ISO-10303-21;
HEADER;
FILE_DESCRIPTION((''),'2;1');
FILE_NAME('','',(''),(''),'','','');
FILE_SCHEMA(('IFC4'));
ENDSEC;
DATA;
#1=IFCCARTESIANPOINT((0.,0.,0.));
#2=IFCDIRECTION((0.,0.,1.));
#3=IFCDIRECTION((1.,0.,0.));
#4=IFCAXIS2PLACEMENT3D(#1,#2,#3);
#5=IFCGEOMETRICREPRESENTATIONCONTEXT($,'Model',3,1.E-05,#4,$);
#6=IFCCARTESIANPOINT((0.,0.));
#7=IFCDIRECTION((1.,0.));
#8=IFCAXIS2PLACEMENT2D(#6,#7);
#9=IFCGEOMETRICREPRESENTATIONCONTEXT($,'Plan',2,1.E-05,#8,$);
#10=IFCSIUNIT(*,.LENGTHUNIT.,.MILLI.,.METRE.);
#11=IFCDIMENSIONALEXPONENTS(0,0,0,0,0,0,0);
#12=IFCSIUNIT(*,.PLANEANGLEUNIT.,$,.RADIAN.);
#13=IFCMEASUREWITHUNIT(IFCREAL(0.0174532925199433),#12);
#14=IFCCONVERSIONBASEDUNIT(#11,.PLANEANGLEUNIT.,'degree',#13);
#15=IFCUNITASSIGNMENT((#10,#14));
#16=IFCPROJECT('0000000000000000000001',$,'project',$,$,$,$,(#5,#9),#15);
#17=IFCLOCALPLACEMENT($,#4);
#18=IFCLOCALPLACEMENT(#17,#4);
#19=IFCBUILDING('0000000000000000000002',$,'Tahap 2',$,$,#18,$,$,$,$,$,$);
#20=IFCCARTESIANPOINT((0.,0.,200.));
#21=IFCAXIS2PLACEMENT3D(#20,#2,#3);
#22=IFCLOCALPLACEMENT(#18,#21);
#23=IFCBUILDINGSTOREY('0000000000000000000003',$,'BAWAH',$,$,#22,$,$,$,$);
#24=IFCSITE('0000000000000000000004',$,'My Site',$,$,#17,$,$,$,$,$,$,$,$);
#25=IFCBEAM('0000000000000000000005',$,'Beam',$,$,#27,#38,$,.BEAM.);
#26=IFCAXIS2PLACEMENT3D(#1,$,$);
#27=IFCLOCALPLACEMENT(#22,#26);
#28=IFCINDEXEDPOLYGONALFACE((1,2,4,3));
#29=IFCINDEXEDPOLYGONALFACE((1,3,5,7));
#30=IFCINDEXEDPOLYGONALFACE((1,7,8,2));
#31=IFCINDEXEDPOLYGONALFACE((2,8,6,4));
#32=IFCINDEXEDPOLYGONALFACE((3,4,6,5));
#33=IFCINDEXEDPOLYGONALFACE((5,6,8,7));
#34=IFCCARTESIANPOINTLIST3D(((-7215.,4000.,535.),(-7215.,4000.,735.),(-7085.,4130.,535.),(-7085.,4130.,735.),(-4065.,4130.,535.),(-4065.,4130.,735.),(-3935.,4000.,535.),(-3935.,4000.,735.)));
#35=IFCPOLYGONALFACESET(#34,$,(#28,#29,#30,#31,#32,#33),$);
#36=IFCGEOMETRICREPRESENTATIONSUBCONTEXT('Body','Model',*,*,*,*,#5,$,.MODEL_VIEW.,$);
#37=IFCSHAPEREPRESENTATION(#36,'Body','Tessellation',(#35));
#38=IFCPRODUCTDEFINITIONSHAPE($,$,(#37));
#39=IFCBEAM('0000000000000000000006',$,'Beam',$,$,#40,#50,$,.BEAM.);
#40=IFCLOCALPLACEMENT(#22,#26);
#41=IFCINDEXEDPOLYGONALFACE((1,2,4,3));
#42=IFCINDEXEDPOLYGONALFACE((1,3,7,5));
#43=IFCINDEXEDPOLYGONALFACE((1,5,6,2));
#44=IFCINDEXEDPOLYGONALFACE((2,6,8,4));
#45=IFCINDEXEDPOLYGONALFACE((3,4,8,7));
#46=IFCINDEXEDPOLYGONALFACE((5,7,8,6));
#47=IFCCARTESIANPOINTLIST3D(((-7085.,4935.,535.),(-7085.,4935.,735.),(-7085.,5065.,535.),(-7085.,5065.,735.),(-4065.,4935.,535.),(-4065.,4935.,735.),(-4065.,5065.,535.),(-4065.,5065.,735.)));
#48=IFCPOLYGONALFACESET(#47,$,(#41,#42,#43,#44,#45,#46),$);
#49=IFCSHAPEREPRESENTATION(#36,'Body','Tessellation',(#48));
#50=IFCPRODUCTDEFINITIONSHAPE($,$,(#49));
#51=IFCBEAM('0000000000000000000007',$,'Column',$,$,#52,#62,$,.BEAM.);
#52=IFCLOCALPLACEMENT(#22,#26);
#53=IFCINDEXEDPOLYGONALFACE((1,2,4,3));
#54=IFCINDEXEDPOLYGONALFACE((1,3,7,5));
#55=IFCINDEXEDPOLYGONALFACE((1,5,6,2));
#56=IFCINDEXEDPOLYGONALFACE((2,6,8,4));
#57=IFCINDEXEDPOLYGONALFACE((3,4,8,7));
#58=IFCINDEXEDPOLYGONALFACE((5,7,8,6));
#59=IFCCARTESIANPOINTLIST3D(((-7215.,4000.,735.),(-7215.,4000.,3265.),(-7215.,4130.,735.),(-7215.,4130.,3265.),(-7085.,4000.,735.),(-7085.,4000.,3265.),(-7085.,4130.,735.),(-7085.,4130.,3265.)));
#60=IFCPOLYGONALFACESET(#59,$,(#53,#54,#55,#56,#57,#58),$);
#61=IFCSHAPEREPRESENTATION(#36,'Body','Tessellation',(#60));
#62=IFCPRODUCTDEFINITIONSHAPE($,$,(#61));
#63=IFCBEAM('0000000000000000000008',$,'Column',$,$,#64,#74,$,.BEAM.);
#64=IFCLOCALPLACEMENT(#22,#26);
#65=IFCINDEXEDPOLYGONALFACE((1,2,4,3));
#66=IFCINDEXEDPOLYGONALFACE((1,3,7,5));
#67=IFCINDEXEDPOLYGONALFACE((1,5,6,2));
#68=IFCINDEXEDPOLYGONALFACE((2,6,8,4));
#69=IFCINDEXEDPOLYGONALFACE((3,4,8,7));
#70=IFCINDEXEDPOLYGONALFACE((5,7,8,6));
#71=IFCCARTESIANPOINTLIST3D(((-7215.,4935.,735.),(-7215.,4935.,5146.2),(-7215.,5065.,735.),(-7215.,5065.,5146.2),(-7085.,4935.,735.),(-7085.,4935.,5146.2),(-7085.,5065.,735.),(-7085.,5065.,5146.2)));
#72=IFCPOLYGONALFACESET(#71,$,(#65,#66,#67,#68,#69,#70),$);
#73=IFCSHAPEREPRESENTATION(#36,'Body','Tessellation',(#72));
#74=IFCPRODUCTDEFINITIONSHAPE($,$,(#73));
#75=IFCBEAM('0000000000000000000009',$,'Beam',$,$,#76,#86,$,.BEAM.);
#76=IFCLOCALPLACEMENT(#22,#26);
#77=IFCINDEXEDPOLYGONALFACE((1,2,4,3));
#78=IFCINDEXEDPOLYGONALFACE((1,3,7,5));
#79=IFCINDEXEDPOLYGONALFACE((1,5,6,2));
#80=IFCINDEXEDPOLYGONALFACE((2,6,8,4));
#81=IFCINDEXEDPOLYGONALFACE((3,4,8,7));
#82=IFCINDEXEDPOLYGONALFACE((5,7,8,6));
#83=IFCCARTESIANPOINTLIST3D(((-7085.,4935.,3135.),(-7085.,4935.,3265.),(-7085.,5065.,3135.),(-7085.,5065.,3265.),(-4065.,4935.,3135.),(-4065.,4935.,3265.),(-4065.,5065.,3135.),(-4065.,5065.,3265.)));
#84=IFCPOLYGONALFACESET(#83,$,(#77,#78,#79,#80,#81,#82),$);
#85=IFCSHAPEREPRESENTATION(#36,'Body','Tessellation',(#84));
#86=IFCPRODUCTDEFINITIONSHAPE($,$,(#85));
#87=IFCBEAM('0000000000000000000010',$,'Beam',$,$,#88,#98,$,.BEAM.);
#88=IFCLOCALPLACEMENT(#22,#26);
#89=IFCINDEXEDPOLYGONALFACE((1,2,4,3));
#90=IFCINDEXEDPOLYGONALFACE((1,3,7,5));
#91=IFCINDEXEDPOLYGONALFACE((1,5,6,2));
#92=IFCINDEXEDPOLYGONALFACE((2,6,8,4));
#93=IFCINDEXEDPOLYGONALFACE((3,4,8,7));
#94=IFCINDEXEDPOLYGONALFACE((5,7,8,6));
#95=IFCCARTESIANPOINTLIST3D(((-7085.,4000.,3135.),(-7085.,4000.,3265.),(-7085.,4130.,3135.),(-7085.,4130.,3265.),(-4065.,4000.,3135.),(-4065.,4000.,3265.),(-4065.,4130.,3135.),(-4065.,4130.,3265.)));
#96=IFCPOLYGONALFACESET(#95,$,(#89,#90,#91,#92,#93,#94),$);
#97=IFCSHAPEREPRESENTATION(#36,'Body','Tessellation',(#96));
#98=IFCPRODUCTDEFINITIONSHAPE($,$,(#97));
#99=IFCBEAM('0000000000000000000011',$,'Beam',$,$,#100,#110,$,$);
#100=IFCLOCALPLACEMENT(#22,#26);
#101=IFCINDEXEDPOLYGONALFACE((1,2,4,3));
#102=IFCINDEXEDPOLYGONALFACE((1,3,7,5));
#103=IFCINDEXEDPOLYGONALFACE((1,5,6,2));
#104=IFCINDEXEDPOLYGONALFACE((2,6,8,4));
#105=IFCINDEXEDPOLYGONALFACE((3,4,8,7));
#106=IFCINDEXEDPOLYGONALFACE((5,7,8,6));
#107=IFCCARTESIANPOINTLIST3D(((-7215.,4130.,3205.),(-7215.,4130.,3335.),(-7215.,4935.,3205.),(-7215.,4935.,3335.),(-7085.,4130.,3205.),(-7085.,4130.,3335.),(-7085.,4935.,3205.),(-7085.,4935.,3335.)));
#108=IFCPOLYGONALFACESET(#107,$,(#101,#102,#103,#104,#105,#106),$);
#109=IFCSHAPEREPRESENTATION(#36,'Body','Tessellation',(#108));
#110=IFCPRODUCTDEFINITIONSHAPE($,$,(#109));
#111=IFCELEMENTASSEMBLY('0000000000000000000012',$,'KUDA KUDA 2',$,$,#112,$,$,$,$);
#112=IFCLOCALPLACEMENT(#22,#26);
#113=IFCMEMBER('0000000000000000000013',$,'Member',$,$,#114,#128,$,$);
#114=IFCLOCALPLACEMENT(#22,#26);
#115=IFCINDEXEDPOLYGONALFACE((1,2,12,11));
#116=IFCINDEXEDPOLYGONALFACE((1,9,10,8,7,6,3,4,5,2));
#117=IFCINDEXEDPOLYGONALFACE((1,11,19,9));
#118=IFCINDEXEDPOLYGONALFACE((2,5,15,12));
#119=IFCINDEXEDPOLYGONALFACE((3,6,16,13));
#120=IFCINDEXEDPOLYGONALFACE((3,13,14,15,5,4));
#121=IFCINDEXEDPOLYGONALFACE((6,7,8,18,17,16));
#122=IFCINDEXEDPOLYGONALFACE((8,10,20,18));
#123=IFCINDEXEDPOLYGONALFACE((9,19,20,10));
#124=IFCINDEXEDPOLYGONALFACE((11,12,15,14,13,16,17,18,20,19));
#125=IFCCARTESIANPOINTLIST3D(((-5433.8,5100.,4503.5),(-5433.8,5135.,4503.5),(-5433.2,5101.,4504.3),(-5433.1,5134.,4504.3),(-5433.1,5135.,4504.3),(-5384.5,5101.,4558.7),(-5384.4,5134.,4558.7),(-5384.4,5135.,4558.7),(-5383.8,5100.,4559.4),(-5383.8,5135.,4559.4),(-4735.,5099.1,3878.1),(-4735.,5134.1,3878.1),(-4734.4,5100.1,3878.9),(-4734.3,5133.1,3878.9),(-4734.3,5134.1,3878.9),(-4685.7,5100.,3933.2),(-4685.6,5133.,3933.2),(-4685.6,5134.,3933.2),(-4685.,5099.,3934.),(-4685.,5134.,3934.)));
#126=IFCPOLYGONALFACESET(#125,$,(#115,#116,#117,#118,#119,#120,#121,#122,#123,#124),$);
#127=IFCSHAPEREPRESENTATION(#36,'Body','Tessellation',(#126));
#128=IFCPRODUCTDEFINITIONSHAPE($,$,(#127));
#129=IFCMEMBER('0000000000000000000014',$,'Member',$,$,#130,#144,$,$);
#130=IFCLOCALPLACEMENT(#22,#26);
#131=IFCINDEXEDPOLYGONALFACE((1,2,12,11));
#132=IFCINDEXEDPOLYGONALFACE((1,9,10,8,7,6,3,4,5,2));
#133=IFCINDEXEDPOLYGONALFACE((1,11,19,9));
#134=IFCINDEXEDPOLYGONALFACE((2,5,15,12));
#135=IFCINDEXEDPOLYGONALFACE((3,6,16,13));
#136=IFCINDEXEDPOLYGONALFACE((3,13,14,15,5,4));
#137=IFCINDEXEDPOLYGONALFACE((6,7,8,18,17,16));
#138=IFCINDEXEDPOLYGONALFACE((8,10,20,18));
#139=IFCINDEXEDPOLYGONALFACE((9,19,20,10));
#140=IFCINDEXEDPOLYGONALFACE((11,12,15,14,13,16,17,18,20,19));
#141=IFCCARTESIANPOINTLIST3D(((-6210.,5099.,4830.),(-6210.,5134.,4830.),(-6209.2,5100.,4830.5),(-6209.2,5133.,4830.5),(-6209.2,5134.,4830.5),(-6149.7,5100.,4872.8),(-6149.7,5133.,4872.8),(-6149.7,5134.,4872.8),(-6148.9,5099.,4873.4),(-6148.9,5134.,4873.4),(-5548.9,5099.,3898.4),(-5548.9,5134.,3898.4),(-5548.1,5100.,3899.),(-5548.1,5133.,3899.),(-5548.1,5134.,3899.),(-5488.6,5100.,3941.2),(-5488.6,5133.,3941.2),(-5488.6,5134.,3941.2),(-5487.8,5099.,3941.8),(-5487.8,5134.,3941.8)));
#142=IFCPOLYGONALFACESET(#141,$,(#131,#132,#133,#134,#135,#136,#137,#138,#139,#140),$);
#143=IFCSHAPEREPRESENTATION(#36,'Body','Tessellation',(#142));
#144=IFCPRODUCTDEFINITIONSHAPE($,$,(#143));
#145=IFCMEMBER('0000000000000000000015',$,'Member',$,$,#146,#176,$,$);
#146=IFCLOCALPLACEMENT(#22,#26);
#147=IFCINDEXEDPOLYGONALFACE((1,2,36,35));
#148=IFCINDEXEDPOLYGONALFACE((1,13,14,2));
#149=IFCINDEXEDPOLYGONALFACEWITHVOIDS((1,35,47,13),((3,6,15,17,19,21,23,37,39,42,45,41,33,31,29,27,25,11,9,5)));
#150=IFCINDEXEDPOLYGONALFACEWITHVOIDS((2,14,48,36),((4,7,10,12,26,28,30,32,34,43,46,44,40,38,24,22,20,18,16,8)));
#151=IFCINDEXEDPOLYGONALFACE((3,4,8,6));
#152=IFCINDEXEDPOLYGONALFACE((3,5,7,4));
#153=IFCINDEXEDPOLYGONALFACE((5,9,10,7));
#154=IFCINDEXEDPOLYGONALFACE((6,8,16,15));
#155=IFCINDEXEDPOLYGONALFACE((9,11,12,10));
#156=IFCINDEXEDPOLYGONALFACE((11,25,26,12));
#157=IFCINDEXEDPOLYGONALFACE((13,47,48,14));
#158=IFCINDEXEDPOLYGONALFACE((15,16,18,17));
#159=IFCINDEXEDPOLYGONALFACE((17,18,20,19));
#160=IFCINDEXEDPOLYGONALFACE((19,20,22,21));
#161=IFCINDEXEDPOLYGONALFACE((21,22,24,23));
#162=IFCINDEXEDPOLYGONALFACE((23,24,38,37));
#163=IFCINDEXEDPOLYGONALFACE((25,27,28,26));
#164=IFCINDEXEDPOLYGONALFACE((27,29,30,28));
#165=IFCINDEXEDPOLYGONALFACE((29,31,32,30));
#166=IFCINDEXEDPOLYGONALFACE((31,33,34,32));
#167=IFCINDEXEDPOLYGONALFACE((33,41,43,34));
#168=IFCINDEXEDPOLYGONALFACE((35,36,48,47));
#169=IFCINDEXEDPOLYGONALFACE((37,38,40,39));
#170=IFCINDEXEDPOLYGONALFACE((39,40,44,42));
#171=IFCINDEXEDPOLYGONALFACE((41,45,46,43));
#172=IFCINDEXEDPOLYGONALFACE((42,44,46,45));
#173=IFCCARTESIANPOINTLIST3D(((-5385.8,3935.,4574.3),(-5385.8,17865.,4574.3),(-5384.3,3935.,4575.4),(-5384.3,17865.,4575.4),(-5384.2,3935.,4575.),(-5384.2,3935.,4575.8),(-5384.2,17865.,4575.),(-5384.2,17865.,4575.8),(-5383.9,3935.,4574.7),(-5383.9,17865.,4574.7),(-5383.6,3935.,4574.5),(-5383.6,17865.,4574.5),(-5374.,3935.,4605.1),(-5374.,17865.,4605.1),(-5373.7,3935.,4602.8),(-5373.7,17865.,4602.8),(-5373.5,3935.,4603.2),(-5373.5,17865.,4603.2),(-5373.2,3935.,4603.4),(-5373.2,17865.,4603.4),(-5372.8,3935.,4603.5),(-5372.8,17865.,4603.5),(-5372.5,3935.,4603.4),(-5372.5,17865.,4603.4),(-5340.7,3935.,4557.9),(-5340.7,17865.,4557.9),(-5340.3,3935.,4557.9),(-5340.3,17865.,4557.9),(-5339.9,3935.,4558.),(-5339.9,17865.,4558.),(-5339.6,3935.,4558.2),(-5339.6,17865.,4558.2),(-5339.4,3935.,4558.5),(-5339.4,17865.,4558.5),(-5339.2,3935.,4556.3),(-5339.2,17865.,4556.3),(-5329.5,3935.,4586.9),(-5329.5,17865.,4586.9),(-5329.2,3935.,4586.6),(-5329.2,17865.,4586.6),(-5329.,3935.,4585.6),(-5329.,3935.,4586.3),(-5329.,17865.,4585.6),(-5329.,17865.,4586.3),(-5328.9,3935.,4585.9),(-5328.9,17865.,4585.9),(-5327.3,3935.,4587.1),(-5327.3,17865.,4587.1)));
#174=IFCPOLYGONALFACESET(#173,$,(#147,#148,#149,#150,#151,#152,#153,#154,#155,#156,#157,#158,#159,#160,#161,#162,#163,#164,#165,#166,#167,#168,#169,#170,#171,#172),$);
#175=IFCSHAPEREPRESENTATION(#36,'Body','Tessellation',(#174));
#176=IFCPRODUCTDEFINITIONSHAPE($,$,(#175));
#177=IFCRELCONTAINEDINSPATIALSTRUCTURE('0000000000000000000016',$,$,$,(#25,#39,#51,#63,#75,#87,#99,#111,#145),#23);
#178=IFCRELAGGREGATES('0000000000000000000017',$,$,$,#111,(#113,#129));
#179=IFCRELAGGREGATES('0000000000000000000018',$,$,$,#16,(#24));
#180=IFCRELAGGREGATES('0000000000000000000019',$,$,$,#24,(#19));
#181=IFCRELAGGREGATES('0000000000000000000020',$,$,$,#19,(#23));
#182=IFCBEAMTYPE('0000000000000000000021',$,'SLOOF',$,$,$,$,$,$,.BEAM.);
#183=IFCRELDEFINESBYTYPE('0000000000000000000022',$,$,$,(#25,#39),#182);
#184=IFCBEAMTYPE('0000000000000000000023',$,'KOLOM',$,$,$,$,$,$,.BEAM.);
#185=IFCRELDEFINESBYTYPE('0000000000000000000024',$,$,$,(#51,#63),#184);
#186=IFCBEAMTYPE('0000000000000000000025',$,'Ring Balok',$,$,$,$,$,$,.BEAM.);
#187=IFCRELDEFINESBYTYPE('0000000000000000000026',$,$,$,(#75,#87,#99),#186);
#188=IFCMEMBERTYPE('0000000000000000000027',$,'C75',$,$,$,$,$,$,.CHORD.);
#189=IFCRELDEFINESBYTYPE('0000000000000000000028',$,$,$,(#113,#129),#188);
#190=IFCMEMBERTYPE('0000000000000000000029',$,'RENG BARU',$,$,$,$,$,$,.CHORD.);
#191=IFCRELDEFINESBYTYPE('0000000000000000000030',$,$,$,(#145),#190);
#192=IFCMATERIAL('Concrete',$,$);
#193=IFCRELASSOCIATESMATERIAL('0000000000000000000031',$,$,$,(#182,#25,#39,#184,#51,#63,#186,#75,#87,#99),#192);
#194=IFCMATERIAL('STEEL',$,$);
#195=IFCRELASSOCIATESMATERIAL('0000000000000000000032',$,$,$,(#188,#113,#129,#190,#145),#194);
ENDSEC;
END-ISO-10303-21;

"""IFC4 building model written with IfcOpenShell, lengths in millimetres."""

from ifc_helpers import new_model, entity, si_unit, converted_unit, frame, origin_with_axes, origin_2d_with_axis, place, context, subcontext, project, spatial, indexed_curve, rectangle, hollow_rectangle, c_section, outline, extrude, clip, halfspace, material, material_profile, profile_set, profile_usage, type_object, element, aggregate, save


model = new_model("IFC4")

# Units and contexts
model_context = context("Model", 3, precision=1e-05, world=origin_with_axes())
plan_context = context("Plan", 2, precision=1e-05, world=origin_2d_with_axis())
body_context = subcontext(model_context, "Body", "Model", "MODEL_VIEW")
ifc_project = project(units=[si_unit("LENGTHUNIT", "METRE", prefix="MILLI"), converted_unit("PLANEANGLEUNIT", "degree", entity("IfcReal", 0.0174532925199433), si_unit("PLANEANGLEUNIT", "RADIAN"), dimensions=[0, 0, 0, 0, 0, 0, 0])], contexts=[model_context, plan_context])

# Site, building, storey
site_placement = place(None, origin_with_axes())
site = spatial("IfcSite", under=ifc_project, at=site_placement, Name="My Site")
building_placement = place(site_placement, origin_with_axes())
building = spatial("IfcBuilding", under=site, at=building_placement, Name="Tahap 2")
storey_placement = place(building_placement, frame((0.0, 0.0, 200.0), z_axis=(0.0, 0.0, 1.0), x_axis=(1.0, 0.0, 0.0)))
storey = spatial("IfcBuildingStorey", under=building, at=storey_placement, Name="BAWAH")

# Beams
ifc_material_1 = material(Name="Concrete")
ifc_material_profile_1 = material_profile(ifc_material_1, outline(indexed_curve([(-65.0, 100.0), (65.0, 100.0), (65.0, -100.0), (-65.0, -100.0), (-65.0, 100.0)])))
ifc_profile_set_1 = profile_set([ifc_material_profile_1])
ifc_profile_usage_1 = profile_usage(ifc_profile_set_1, cardinal=2)
beam_type_1 = type_object("IfcBeamType", Name="SLOOF", PredefinedType="BEAM", material=ifc_profile_set_1)
beam_1_placement = place(storey_placement, frame((-7215.0, 4065.0, 535.0), z_axis=(1.0, 0.0, 0.0), x_axis=(0.0, 1.0, 0.0)))
element("IfcBeam", 1, at=beam_1_placement, inside=storey, type_object=beam_type_1, material=ifc_profile_usage_1, Name="Beam", PredefinedType="BEAM", context=body_context, shape_type="Clipping", body=[
    clip(clip(extrude(outline(indexed_curve([(-65.0, 100.0), (65.0, 100.0), (65.0, -100.0), (-65.0, -100.0), (-65.0, 100.0)])), frame((0.0, 100.0, 0.0), z_axis=(0.0, 0.0, 1.0), x_axis=(1.0, 0.0, 0.0)), (0.0, 0.0, 1.0), 3280.0), halfspace(frame((-65.0, -735.0, 3280.0), z_axis=(0.707107, 0.0, 0.707107), x_axis=(0.0, -1.0, 0.0)), False)), halfspace(frame((-65.0, -735.0, 0.0), z_axis=(0.707107, 0.0, -0.707107), x_axis=(0.0, -1.0, 0.0)), False)),
])
ifc_profile_usage_2 = profile_usage(ifc_profile_set_1, cardinal=2)
beam_2_placement = place(storey_placement, frame((-7085.0, 5000.0, 535.0), z_axis=(1.0, 0.0, 0.0), x_axis=(0.0, 1.0, 0.0)))
element("IfcBeam", 2, at=beam_2_placement, inside=storey, type_object=beam_type_1, material=ifc_profile_usage_2, Name="Beam", PredefinedType="BEAM", context=body_context, shape_type="SweptSolid", body=[
    extrude(outline(indexed_curve([(-65.0, 100.0), (65.0, 100.0), (65.0, -100.0), (-65.0, -100.0), (-65.0, 100.0)])), frame((0.0, 100.0, 0.0), z_axis=(0.0, 0.0, 1.0), x_axis=(1.0, 0.0, 0.0)), (0.0, 0.0, 1.0), 3020.0),
])
ifc_material_profile_2 = material_profile(ifc_material_1, rectangle(XDim=130.0, YDim=130.0, kind="CURVE"))
ifc_profile_set_2 = profile_set([ifc_material_profile_2])
ifc_profile_usage_3 = profile_usage(ifc_profile_set_2, cardinal=5)
beam_type_2 = type_object("IfcBeamType", Name="KOLOM", PredefinedType="BEAM", material=ifc_profile_set_2)
beam_3_placement = place(storey_placement, frame((-7150.0, 4065.0, 735.0), z_axis=(0.0, 0.0, 1.0), x_axis=(1.0, 0.0, 0.0)))
element("IfcBeam", 3, at=beam_3_placement, inside=storey, type_object=beam_type_2, material=ifc_profile_usage_3, Name="Column", PredefinedType="BEAM", context=body_context, shape_type="SweptSolid", body=[
    extrude(rectangle(XDim=130.0, YDim=130.0, kind="CURVE"), origin_with_axes(), (0.0, 0.0, 1.0), 2530.0),
])
ifc_profile_usage_4 = profile_usage(ifc_profile_set_2, cardinal=5)
beam_4_placement = place(storey_placement, frame((-7150.0, 5000.0, 735.0), z_axis=(0.0, 0.0, 1.0), x_axis=(1.0, 0.0, 0.0)))
element("IfcBeam", 4, at=beam_4_placement, inside=storey, type_object=beam_type_2, material=ifc_profile_usage_4, Name="Column", PredefinedType="BEAM", context=body_context, shape_type="SweptSolid", body=[
    extrude(rectangle(XDim=130.0, YDim=130.0, kind="CURVE"), origin_with_axes(), (0.0, 0.0, 1.0), 4411.2),
])
ifc_material_profile_3 = material_profile(ifc_material_1, rectangle(XDim=130.0, YDim=130.0))
ifc_profile_set_3 = profile_set([ifc_material_profile_3])
ifc_profile_usage_5 = profile_usage(ifc_profile_set_3)
beam_type_3 = type_object("IfcBeamType", Name="Ring Balok", PredefinedType="BEAM", material=ifc_profile_set_3)
beam_5_placement = place(storey_placement, frame((-7085.0, 5000.0, 3200.0), z_axis=(1.0, 0.0, 0.0), x_axis=(0.0, 1.0, 0.0)))
element("IfcBeam", 5, at=beam_5_placement, inside=storey, type_object=beam_type_3, material=ifc_profile_usage_5, Name="Beam", PredefinedType="BEAM", context=body_context, shape_type="SweptSolid", body=[
    extrude(rectangle(XDim=130.0, YDim=130.0), origin_with_axes(), (0.0, 0.0, 1.0), 3020.0),
])
ifc_profile_usage_6 = profile_usage(ifc_profile_set_3)
beam_6_placement = place(storey_placement, frame((-7085.0, 4065.0, 3200.0), z_axis=(1.0, 0.0, 0.0), x_axis=(0.0, 1.0, 0.0)))
element("IfcBeam", 6, at=beam_6_placement, inside=storey, type_object=beam_type_3, material=ifc_profile_usage_6, Name="Beam", PredefinedType="BEAM", context=body_context, shape_type="SweptSolid", body=[
    extrude(rectangle(XDim=130.0, YDim=130.0), origin_with_axes(), (0.0, 0.0, 1.0), 3020.0),
])
ifc_profile_usage_7 = profile_usage(ifc_profile_set_3, cardinal=9)
beam_7_placement = place(storey_placement, frame((-7085.0, 4130.0, 3335.0), z_axis=(0.0, 1.0, 0.0), x_axis=(-1.0, 0.0, 0.0)))
element("IfcBeam", 7, at=beam_7_placement, inside=storey, type_object=beam_type_3, material=ifc_profile_usage_7, Name="Beam", context=body_context, shape_type="SweptSolid", body=[
    extrude(rectangle(XDim=130.0, YDim=130.0), frame((65.0, -65.0, 0.0), z_axis=(0.0, 0.0, 1.0), x_axis=(1.0, 0.0, 0.0)), (0.0, 0.0, 1.0), 805.0),
])

# Element assembly, members
assembly_placement = place(storey_placement, frame((-3938.5, 5099.0, 3935.3), z_axis=(0.0, 0.0, 1.0), x_axis=(1.0, 0.0, 0.0)))
assembly = element("IfcElementAssembly", 8, at=assembly_placement, inside=storey, Name="KUDA KUDA 2")
ifc_material_2 = material(Name="STEEL")
ifc_material_profile_4 = material_profile(ifc_material_2, c_section(Depth=75.0, Width=35.0, WallThickness=1.0, Girth=1.0, kind="CURVE"))
ifc_profile_set_4 = profile_set([ifc_material_profile_4])
member_type_1 = type_object("IfcMemberType", Name="C75", PredefinedType="CHORD", material=ifc_profile_set_4)
ifc_profile_usage_8 = profile_usage(ifc_profile_set_4, cardinal=7)
member_1_placement = place(assembly_placement, frame((-1445.3, 36.0, 624.1), z_axis=(0.745142, -0.001027, -0.666905), x_axis=(0.001378, 0.999999, 0.0)))
member_1 = element("IfcMember", 9, at=member_1_placement, type_object=member_type_1, material=ifc_profile_usage_8, Name="Member", context=body_context, shape_type="SweptSolid", body=[
    extrude(c_section(Depth=75.0, Width=35.0, WallThickness=1.0, Girth=1.0, kind="CURVE"), frame((-17.5, -37.5, 0.0), z_axis=(0.0, 0.0, 1.0), x_axis=(1.0, 0.0, 0.0)), (0.0, 0.0, 1.0), 937.8),
])
ifc_profile_usage_9 = profile_usage(ifc_profile_set_4, cardinal=3)
member_2_placement = place(assembly_placement, frame((-2271.5, 0.0, 894.6), z_axis=(0.578723, -0.000001, -0.815524), x_axis=(0.000001, 1.0, 0.0)))
member_2 = element("IfcMember", 10, at=member_2_placement, type_object=member_type_1, material=ifc_profile_usage_9, Name="Member", context=body_context, shape_type="SweptSolid", body=[
    extrude(c_section(Depth=75.0, Width=35.0, WallThickness=1.0, Girth=1.0, kind="CURVE"), frame((17.5, 37.5, 0.0), z_axis=(0.0, 0.0, 1.0), x_axis=(1.0, 0.0, 0.0)), (0.0, 0.0, 1.0), 1142.3),
])
aggregate(assembly, [member_1, member_2])

# Member
ifc_material_profile_5 = material_profile(ifc_material_2, hollow_rectangle(XDim=50.0, YDim=33.0, WallThickness=1.0, InnerFilletRadius=1.0, OuterFilletRadius=0.0, kind="CURVE"))
ifc_profile_set_5 = profile_set([ifc_material_profile_5])
ifc_profile_usage_10 = profile_usage(ifc_profile_set_5, cardinal=3)
member_type_2 = type_object("IfcMemberType", Name="RENG BARU", PredefinedType="CHORD", material=ifc_profile_set_5)
member_3_placement = place(storey_placement, frame((-5339.2, 3935.0, 4556.3), z_axis=(0.0, 1.0, 0.0), x_axis=(-0.932954, 0.0, 0.359997)))
element("IfcMember", 11, at=member_3_placement, inside=storey, type_object=member_type_2, material=ifc_profile_usage_10, Name="Member", context=body_context, shape_type="SweptSolid", body=[
    extrude(hollow_rectangle(XDim=50.0, YDim=33.0, WallThickness=1.0, InnerFilletRadius=1.0, OuterFilletRadius=0.0, kind="CURVE"), frame((25.0, 16.5, 0.0), z_axis=(0.0, 0.0, 1.0), x_axis=(1.0, 0.0, 0.0)), (0.0, 0.0, 1.0), 13930.0),
])

save(model, "model.ifc")
